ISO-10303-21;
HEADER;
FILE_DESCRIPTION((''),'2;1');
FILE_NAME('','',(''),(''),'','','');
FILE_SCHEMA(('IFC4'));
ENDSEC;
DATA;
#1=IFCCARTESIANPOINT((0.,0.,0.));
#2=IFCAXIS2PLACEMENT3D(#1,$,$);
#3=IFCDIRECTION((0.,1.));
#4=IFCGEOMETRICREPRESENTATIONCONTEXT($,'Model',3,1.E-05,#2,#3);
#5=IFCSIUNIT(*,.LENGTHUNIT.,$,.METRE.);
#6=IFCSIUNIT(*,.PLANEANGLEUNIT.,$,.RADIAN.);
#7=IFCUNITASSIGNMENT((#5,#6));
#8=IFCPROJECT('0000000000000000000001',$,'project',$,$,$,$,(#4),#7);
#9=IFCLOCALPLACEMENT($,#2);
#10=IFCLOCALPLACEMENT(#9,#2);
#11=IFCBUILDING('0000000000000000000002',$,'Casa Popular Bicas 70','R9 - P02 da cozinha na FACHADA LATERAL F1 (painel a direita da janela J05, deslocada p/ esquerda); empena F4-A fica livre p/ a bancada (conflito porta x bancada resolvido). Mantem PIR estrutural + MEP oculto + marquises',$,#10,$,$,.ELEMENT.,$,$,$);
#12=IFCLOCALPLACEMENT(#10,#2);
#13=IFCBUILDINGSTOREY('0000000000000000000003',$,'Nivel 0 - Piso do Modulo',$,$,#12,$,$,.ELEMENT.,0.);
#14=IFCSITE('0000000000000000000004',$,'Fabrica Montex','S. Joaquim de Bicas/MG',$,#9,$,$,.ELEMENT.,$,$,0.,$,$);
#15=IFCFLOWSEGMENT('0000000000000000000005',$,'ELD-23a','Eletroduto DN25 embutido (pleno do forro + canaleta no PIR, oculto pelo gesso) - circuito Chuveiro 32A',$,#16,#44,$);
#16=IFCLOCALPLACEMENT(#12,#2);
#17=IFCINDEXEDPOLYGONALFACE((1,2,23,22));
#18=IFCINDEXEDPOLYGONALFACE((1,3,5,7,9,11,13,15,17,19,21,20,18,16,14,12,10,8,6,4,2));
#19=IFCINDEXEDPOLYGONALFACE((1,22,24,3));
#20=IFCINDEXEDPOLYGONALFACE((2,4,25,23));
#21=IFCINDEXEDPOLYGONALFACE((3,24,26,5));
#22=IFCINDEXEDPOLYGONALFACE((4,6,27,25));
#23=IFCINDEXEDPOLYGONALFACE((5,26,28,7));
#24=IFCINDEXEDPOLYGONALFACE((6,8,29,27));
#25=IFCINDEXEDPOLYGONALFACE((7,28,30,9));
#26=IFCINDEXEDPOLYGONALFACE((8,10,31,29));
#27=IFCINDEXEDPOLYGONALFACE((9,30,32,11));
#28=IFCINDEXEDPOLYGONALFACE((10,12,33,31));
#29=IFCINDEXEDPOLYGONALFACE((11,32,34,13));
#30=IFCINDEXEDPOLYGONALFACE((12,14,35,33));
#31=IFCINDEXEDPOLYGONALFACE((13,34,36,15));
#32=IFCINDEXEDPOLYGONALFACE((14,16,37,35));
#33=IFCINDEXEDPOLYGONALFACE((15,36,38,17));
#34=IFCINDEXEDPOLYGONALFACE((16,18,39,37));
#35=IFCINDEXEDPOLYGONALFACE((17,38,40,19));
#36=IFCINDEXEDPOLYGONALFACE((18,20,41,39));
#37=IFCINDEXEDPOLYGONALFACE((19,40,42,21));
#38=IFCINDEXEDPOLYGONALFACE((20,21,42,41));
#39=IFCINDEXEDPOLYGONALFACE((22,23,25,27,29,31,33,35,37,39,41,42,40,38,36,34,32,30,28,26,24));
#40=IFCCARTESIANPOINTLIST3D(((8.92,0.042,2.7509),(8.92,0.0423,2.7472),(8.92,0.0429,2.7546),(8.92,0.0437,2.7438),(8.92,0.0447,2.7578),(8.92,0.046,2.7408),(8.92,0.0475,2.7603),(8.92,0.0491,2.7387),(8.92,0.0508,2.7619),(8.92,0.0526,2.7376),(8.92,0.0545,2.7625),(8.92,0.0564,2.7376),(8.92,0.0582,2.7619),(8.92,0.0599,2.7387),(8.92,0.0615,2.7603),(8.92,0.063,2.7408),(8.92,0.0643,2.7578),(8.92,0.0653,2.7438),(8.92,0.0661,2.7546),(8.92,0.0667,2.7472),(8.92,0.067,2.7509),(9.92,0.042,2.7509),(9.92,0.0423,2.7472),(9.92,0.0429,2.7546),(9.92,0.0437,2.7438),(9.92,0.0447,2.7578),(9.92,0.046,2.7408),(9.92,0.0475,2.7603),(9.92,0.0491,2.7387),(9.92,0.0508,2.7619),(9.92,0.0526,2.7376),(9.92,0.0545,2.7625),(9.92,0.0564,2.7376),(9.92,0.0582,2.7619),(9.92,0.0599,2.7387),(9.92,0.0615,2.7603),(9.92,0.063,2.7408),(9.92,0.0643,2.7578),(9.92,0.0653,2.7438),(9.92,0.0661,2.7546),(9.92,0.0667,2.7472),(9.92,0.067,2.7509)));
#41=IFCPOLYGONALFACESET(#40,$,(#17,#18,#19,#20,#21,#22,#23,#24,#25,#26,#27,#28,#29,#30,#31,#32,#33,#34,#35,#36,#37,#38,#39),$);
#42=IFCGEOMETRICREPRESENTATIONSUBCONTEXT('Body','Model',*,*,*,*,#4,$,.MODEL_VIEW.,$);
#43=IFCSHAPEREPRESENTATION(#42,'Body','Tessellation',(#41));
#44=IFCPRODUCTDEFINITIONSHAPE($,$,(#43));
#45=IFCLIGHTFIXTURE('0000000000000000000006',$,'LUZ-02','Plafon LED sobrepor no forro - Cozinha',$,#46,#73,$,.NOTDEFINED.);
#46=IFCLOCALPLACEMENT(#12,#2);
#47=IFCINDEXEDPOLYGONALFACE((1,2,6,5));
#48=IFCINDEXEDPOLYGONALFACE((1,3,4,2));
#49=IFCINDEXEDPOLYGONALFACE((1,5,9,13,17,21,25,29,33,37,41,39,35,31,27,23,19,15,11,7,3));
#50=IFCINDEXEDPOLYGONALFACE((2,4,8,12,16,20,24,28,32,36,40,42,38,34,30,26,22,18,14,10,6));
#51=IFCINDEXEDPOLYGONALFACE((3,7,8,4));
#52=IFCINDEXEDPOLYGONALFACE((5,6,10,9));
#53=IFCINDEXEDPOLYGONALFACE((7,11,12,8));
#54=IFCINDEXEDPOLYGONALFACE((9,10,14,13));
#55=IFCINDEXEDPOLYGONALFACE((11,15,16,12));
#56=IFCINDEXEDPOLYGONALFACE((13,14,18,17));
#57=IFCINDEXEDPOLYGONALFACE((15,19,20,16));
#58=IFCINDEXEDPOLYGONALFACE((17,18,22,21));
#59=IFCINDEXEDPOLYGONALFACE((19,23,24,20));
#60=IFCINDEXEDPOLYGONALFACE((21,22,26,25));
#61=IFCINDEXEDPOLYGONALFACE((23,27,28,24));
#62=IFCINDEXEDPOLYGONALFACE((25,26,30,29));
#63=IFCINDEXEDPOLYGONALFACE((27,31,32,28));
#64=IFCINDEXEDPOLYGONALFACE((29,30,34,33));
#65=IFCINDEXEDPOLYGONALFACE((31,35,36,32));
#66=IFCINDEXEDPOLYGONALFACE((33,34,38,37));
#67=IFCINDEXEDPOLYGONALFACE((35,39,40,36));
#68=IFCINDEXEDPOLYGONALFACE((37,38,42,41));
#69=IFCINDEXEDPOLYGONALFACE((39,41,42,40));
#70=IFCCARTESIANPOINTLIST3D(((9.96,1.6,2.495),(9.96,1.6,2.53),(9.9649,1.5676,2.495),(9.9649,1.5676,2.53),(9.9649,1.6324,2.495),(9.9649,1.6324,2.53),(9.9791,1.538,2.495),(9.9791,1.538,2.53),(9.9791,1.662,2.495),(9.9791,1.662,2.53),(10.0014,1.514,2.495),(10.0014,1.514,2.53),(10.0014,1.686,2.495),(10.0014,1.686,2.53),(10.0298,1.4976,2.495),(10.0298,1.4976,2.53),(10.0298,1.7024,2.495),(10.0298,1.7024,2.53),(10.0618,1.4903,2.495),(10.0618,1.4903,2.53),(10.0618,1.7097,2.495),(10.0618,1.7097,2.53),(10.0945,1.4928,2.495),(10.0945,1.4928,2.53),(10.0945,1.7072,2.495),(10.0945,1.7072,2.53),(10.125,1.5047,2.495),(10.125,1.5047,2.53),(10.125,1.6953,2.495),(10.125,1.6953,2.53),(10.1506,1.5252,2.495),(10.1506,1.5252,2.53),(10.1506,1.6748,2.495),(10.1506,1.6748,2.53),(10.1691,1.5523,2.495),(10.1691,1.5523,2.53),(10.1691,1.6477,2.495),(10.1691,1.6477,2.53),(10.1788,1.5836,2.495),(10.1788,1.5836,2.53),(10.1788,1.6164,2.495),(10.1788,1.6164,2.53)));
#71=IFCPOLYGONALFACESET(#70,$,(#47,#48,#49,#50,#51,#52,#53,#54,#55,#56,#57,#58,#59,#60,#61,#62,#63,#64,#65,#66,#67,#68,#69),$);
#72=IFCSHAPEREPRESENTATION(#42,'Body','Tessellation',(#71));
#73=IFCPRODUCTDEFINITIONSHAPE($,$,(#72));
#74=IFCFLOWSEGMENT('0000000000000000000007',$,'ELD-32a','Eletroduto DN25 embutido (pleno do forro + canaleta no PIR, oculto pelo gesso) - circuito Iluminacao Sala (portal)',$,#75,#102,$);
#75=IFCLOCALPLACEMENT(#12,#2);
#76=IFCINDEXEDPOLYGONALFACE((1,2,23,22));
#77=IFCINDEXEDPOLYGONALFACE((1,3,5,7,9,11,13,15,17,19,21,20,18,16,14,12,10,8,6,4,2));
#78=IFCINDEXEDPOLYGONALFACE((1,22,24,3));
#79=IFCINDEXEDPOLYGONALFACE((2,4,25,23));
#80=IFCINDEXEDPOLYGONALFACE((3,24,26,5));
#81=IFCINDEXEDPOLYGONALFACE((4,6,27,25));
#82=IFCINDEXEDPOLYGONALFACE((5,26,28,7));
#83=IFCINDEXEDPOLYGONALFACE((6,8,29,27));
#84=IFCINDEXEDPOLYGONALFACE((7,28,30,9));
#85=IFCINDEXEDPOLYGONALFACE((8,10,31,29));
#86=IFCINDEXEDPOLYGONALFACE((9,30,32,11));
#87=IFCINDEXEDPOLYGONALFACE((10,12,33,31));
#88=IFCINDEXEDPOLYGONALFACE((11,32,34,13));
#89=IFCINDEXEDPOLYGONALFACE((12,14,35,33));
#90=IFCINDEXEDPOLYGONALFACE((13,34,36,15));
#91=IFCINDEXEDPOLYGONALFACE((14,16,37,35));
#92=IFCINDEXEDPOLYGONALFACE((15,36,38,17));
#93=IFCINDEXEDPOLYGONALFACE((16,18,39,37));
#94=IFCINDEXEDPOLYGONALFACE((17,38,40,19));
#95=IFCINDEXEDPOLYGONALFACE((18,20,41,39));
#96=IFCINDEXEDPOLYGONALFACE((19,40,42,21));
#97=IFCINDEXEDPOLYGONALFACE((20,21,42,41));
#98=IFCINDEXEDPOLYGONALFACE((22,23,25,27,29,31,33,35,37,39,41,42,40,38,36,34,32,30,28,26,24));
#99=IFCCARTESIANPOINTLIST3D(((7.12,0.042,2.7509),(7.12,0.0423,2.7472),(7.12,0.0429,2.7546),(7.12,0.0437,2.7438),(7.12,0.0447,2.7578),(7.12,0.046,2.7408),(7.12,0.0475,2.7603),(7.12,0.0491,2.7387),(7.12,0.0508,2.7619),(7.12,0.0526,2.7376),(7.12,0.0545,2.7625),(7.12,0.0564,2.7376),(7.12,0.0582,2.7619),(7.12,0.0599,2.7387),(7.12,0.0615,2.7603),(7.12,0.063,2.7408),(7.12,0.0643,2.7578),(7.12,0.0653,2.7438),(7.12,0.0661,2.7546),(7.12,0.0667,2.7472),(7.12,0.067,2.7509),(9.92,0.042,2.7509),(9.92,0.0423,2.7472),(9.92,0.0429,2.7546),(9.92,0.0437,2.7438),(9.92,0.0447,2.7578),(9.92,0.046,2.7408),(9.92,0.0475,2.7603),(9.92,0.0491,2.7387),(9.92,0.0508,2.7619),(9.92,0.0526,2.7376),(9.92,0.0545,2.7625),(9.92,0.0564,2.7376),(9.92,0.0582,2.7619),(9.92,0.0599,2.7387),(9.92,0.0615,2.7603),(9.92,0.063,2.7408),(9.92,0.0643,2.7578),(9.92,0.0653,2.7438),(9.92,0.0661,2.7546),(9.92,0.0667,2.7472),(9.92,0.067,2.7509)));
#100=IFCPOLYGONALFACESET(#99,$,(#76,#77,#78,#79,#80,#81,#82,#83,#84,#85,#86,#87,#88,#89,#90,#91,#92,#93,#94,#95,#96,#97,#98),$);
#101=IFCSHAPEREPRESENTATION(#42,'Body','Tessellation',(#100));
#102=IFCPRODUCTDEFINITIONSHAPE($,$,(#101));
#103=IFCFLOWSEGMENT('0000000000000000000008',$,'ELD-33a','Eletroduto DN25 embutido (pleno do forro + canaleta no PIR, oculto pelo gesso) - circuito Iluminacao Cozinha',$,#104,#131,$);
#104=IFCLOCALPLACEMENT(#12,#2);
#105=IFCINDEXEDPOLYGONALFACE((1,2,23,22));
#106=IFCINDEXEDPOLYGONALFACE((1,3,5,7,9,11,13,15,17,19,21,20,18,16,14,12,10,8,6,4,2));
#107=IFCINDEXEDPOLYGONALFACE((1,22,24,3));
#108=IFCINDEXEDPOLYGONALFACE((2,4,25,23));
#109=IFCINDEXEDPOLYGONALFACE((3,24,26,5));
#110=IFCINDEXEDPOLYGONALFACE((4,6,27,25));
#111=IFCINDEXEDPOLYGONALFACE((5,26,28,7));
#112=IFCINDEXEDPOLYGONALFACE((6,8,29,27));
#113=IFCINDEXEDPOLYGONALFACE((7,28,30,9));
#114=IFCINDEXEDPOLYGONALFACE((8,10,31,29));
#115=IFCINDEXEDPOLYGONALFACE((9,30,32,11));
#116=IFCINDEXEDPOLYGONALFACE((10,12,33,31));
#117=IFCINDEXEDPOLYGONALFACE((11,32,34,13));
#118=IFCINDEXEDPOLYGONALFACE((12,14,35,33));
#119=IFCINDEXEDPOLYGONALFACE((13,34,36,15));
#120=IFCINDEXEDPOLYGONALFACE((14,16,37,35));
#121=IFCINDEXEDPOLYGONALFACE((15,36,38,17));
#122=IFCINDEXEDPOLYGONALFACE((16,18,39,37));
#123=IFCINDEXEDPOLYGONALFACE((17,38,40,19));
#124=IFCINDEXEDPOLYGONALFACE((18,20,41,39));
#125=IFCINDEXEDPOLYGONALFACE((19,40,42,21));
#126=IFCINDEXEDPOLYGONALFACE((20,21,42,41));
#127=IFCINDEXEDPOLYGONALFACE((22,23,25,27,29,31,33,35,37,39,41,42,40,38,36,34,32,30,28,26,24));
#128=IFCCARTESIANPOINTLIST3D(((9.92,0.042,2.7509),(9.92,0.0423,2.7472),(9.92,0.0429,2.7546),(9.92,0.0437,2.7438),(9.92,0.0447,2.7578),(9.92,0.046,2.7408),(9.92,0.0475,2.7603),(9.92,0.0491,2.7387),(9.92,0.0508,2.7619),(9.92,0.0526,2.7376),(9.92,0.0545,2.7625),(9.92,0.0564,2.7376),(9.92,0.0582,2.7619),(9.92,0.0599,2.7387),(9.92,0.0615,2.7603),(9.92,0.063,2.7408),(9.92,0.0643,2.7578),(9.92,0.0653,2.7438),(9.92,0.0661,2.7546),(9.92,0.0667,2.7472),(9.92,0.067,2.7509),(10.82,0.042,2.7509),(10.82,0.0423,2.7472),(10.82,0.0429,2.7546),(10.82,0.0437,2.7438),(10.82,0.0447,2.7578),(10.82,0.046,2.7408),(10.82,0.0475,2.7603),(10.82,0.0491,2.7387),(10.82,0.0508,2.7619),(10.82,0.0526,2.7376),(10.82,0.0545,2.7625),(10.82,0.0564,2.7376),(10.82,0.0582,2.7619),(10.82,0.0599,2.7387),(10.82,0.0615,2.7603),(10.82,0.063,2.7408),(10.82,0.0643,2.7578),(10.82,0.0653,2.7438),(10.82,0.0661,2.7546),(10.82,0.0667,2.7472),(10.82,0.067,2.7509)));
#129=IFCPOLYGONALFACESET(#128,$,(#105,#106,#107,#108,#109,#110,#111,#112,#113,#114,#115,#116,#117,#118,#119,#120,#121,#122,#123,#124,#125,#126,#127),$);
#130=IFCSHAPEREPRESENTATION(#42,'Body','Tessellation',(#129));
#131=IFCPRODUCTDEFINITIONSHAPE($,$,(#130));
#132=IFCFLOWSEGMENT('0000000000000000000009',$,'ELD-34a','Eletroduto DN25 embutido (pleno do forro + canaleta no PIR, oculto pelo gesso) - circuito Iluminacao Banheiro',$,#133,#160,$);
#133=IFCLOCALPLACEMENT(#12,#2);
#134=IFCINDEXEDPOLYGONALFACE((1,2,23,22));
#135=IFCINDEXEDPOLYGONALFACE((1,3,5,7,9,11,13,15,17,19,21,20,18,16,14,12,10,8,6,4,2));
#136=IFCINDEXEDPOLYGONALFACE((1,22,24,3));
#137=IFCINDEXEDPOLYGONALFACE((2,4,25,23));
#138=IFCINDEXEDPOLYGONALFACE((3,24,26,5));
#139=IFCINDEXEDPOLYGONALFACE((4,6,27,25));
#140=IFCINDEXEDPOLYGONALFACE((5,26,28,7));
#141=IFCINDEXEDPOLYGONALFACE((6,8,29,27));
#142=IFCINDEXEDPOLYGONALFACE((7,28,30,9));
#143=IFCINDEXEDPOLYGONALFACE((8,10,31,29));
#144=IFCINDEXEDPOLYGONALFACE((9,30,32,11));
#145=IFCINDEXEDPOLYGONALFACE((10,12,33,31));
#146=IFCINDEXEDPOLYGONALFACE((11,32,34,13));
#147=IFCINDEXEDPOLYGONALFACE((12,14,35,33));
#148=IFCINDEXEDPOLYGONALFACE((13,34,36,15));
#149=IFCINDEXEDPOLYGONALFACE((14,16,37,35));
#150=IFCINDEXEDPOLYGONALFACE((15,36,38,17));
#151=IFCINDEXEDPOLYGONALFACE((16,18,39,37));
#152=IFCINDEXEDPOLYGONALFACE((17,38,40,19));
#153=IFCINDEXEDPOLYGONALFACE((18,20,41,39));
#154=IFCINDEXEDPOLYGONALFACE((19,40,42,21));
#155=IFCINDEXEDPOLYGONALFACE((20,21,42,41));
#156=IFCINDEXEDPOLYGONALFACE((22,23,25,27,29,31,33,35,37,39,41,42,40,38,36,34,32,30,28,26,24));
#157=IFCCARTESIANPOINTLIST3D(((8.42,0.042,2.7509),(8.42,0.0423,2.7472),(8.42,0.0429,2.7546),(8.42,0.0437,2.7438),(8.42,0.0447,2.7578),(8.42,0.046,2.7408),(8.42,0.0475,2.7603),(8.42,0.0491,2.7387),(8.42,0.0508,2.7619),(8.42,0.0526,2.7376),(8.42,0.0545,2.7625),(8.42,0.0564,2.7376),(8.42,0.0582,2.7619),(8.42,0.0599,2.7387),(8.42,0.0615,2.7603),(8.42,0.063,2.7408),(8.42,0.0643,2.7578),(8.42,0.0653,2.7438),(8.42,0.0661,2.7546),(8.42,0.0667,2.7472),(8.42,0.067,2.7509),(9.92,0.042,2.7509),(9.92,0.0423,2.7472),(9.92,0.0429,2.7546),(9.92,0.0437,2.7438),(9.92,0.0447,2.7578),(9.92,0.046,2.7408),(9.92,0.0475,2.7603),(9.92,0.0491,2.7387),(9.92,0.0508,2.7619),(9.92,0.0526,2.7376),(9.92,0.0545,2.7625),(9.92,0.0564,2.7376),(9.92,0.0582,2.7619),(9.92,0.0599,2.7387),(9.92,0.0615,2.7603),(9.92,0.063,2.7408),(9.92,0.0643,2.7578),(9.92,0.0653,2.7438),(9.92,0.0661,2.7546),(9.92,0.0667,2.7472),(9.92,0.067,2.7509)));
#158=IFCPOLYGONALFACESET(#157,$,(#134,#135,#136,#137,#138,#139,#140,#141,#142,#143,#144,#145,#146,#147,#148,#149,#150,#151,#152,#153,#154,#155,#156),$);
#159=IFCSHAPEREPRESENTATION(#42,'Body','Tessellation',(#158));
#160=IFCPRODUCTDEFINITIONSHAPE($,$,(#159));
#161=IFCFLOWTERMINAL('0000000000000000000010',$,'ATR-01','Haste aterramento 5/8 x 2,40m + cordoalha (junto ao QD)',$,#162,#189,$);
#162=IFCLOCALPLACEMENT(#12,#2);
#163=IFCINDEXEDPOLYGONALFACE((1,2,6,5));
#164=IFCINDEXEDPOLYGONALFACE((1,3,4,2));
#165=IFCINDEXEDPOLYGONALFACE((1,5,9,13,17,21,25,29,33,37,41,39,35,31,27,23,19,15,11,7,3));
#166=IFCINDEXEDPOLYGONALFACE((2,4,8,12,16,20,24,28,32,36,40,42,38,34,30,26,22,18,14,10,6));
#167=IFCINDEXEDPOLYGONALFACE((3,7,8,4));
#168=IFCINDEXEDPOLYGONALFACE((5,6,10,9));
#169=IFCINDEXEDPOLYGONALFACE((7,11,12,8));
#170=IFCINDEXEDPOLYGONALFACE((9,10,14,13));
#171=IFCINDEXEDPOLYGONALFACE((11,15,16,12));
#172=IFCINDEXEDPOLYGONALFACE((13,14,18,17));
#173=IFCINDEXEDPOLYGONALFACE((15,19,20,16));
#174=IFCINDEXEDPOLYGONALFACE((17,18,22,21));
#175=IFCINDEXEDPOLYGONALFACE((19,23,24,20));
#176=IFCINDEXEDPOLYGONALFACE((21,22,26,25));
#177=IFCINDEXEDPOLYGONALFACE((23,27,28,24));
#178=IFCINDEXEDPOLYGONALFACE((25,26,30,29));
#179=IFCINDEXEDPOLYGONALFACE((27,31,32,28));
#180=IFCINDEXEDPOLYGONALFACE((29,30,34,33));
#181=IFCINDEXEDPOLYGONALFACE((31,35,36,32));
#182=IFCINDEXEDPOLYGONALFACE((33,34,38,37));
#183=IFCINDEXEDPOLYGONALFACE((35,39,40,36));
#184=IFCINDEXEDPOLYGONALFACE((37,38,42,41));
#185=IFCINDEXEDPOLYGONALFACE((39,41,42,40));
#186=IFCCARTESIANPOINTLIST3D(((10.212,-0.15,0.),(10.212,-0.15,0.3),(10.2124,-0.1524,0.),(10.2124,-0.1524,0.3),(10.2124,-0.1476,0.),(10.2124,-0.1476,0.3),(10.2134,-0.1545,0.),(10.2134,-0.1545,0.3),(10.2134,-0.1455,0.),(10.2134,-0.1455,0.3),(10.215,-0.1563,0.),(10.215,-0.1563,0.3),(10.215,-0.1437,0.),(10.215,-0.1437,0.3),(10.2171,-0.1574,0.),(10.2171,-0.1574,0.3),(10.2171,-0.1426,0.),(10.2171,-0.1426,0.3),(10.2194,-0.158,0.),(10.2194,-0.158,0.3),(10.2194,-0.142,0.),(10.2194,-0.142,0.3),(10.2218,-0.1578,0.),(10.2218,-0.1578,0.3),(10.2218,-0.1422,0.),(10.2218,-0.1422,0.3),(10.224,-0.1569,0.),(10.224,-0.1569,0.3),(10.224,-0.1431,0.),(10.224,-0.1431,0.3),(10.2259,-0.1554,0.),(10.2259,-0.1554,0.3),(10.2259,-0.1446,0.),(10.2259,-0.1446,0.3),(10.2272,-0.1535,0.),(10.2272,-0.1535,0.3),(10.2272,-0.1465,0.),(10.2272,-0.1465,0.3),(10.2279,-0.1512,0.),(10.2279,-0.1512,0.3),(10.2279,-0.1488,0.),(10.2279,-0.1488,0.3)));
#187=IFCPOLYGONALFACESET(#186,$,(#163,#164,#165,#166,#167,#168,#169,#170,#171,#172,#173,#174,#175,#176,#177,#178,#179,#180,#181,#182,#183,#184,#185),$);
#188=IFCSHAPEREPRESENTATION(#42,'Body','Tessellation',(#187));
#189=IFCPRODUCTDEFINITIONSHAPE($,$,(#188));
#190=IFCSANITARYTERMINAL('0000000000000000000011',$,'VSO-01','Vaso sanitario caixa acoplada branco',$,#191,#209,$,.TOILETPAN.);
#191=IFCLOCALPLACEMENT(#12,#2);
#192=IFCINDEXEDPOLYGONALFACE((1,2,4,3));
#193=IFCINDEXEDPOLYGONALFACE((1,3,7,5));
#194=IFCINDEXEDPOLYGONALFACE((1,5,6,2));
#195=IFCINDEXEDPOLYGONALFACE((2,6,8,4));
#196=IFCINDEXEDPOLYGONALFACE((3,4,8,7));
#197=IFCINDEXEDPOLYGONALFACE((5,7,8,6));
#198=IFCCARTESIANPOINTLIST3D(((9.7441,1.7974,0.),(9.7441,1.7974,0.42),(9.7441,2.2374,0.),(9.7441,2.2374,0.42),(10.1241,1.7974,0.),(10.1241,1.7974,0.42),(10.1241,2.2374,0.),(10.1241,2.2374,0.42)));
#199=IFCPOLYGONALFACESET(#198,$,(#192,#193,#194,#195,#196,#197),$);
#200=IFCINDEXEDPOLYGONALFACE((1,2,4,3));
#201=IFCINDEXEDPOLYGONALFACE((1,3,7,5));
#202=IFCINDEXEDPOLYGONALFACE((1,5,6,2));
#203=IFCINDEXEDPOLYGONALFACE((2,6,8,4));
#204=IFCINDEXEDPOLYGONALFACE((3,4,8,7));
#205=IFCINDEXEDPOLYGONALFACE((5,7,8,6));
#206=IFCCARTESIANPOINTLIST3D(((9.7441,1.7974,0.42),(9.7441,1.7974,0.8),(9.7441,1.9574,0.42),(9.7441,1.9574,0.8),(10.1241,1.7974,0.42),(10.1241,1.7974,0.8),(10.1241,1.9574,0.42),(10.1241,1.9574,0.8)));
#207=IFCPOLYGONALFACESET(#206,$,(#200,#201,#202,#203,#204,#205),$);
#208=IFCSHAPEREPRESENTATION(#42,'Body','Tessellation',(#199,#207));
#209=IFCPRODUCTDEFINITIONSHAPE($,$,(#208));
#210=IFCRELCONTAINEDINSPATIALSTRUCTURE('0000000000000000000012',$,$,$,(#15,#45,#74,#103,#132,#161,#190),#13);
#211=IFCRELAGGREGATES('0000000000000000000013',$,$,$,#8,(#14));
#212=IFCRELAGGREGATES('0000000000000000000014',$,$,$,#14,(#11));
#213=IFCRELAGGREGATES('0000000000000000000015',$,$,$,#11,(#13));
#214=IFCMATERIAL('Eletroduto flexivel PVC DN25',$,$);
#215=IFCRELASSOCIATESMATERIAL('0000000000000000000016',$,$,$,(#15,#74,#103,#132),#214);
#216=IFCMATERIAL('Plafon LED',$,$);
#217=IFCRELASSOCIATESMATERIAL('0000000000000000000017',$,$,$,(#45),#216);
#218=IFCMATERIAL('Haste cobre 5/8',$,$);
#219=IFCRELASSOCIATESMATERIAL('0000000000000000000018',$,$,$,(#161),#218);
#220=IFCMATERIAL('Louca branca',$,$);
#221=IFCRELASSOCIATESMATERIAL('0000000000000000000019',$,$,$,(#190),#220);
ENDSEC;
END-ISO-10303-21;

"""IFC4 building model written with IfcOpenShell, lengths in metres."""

from ifc_helpers import new_model, si_unit, direction, frame, frame_2d, origin, origin_2d, place, context, subcontext, project, spatial, rectangle, circle, extrude, material, element, save


model = new_model("IFC4")

# Units and contexts
model_context = context("Model", 3, precision=1e-05, world=origin(), true_north=direction((0.0, 1.0)))
body_context = subcontext(model_context, "Body", "Model", "MODEL_VIEW")
ifc_project = project(units=[si_unit("LENGTHUNIT", "METRE"), si_unit("PLANEANGLEUNIT", "RADIAN")], contexts=[model_context])

# Site, building, storey
site_placement = place(None, origin())
site = spatial("IfcSite", under=ifc_project, at=site_placement, Name="Fabrica Montex", Description="S. Joaquim de Bicas/MG", CompositionType="ELEMENT", RefElevation=0.0)
building_placement = place(site_placement, origin())
building = spatial("IfcBuilding", under=site, at=building_placement, Name="Casa Popular Bicas 70", Description="R9 - P02 da cozinha na FACHADA LATERAL F1 (painel a direita da janela J05, deslocada p/ esquerda); empena F4-A fica livre p/ a bancada (conflito porta x bancada resolvido). Mantem PIR estrutural + MEP oculto + marquises", CompositionType="ELEMENT")
storey_placement = place(building_placement, origin())
storey = spatial("IfcBuildingStorey", under=building, at=storey_placement, Name="Nivel 0 - Piso do Modulo", CompositionType="ELEMENT", Elevation=0.0)

# Flow segment
ifc_material_1 = material(Name="Eletroduto flexivel PVC DN25")
flow_segment_1_placement = place(None, frame((9.92, 0.0545, 2.75), z_axis=(-1.0, 0.0, 0.0), x_axis=(0.0, 0.0, 1.0)))
element("IfcFlowSegment", 1, at=flow_segment_1_placement, inside=storey, material=ifc_material_1, Name="ELD-23a", Description="Eletroduto DN25 embutido (pleno do forro + canaleta no PIR, oculto pelo gesso) - circuito Chuveiro 32A", context=body_context, shape_type="SweptSolid", body=[
    extrude(circle(Radius=0.0125, at=origin_2d()), origin(), (0.0, 0.0, 1.0), 1.0),
])

# Light fixture
ifc_material_2 = material(Name="Plafon LED")
light_fixture_placement = place(None, frame((10.07, 1.6, 2.495), z_axis=(0.0, 0.0, 1.0), x_axis=(-1.0, 0.0, 0.0)))
element("IfcLightFixture", 2, at=light_fixture_placement, inside=storey, material=ifc_material_2, Name="LUZ-02", Description="Plafon LED sobrepor no forro - Cozinha", PredefinedType="NOTDEFINED", context=body_context, shape_type="SweptSolid", body=[
    extrude(circle(Radius=0.11, at=origin_2d()), origin(), (0.0, 0.0, 1.0), 0.035),
])

# Flow segments
flow_segment_2_placement = place(None, frame((9.92, 0.0545, 2.75), z_axis=(-1.0, 0.0, 0.0), x_axis=(0.0, 0.0, 1.0)))
element("IfcFlowSegment", 3, at=flow_segment_2_placement, inside=storey, material=ifc_material_1, Name="ELD-32a", Description="Eletroduto DN25 embutido (pleno do forro + canaleta no PIR, oculto pelo gesso) - circuito Iluminacao Sala (portal)", context=body_context, shape_type="SweptSolid", body=[
    extrude(circle(Radius=0.0125, at=origin_2d()), origin(), (0.0, 0.0, 1.0), 2.8),
])
flow_segment_3_placement = place(None, frame((9.92, 0.0545, 2.75), z_axis=(1.0, 0.0, 0.0), x_axis=(0.0, 0.0, 1.0)))
element("IfcFlowSegment", 4, at=flow_segment_3_placement, inside=storey, material=ifc_material_1, Name="ELD-33a", Description="Eletroduto DN25 embutido (pleno do forro + canaleta no PIR, oculto pelo gesso) - circuito Iluminacao Cozinha", context=body_context, shape_type="SweptSolid", body=[
    extrude(circle(Radius=0.0125, at=origin_2d()), origin(), (0.0, 0.0, 1.0), 0.9),
])
flow_segment_4_placement = place(None, frame((9.92, 0.0545, 2.75), z_axis=(-1.0, 0.0, 0.0), x_axis=(0.0, 0.0, 1.0)))
element("IfcFlowSegment", 5, at=flow_segment_4_placement, inside=storey, material=ifc_material_1, Name="ELD-34a", Description="Eletroduto DN25 embutido (pleno do forro + canaleta no PIR, oculto pelo gesso) - circuito Iluminacao Banheiro", context=body_context, shape_type="SweptSolid", body=[
    extrude(circle(Radius=0.0125, at=origin_2d()), origin(), (0.0, 0.0, 1.0), 1.5),
])

# Flow terminal
ifc_material_3 = material(Name="Haste cobre 5/8")
flow_terminal_placement = place(None, frame((10.22, -0.15, 0.0), z_axis=(0.0, 0.0, 1.0), x_axis=(-1.0, 0.0, 0.0)))
element("IfcFlowTerminal", 6, at=flow_terminal_placement, inside=storey, material=ifc_material_3, Name="ATR-01", Description="Haste aterramento 5/8 x 2,40m + cordoalha (junto ao QD)", context=body_context, shape_type="SweptSolid", body=[
    extrude(circle(Radius=0.008, at=origin_2d()), origin(), (0.0, 0.0, 1.0), 0.3),
])

# Sanitary terminal
ifc_material_4 = material(Name="Louca branca")
sanitary_terminal_placement = place(None, frame((10.1241, 2.2374, 0.0), z_axis=(0.0, 0.0, 1.0), x_axis=(-1.0, 0.0, 0.0)))
element("IfcSanitaryTerminal", 7, at=sanitary_terminal_placement, inside=storey, material=ifc_material_4, Name="VSO-01", Description="Vaso sanitario caixa acoplada branco", PredefinedType="TOILETPAN", context=body_context, shape_type="SweptSolid", body=[
    extrude(rectangle(XDim=0.38, YDim=0.44, at=frame_2d((0.19, 0.22))), origin(), (0.0, 0.0, 1.0), 0.42),
    extrude(rectangle(XDim=0.38, YDim=0.16, at=frame_2d((0.19, 0.36))), frame((0.0, 0.0, 0.42)), (0.0, 0.0, 1.0), 0.38),
])

save(model, "model.ifc")
